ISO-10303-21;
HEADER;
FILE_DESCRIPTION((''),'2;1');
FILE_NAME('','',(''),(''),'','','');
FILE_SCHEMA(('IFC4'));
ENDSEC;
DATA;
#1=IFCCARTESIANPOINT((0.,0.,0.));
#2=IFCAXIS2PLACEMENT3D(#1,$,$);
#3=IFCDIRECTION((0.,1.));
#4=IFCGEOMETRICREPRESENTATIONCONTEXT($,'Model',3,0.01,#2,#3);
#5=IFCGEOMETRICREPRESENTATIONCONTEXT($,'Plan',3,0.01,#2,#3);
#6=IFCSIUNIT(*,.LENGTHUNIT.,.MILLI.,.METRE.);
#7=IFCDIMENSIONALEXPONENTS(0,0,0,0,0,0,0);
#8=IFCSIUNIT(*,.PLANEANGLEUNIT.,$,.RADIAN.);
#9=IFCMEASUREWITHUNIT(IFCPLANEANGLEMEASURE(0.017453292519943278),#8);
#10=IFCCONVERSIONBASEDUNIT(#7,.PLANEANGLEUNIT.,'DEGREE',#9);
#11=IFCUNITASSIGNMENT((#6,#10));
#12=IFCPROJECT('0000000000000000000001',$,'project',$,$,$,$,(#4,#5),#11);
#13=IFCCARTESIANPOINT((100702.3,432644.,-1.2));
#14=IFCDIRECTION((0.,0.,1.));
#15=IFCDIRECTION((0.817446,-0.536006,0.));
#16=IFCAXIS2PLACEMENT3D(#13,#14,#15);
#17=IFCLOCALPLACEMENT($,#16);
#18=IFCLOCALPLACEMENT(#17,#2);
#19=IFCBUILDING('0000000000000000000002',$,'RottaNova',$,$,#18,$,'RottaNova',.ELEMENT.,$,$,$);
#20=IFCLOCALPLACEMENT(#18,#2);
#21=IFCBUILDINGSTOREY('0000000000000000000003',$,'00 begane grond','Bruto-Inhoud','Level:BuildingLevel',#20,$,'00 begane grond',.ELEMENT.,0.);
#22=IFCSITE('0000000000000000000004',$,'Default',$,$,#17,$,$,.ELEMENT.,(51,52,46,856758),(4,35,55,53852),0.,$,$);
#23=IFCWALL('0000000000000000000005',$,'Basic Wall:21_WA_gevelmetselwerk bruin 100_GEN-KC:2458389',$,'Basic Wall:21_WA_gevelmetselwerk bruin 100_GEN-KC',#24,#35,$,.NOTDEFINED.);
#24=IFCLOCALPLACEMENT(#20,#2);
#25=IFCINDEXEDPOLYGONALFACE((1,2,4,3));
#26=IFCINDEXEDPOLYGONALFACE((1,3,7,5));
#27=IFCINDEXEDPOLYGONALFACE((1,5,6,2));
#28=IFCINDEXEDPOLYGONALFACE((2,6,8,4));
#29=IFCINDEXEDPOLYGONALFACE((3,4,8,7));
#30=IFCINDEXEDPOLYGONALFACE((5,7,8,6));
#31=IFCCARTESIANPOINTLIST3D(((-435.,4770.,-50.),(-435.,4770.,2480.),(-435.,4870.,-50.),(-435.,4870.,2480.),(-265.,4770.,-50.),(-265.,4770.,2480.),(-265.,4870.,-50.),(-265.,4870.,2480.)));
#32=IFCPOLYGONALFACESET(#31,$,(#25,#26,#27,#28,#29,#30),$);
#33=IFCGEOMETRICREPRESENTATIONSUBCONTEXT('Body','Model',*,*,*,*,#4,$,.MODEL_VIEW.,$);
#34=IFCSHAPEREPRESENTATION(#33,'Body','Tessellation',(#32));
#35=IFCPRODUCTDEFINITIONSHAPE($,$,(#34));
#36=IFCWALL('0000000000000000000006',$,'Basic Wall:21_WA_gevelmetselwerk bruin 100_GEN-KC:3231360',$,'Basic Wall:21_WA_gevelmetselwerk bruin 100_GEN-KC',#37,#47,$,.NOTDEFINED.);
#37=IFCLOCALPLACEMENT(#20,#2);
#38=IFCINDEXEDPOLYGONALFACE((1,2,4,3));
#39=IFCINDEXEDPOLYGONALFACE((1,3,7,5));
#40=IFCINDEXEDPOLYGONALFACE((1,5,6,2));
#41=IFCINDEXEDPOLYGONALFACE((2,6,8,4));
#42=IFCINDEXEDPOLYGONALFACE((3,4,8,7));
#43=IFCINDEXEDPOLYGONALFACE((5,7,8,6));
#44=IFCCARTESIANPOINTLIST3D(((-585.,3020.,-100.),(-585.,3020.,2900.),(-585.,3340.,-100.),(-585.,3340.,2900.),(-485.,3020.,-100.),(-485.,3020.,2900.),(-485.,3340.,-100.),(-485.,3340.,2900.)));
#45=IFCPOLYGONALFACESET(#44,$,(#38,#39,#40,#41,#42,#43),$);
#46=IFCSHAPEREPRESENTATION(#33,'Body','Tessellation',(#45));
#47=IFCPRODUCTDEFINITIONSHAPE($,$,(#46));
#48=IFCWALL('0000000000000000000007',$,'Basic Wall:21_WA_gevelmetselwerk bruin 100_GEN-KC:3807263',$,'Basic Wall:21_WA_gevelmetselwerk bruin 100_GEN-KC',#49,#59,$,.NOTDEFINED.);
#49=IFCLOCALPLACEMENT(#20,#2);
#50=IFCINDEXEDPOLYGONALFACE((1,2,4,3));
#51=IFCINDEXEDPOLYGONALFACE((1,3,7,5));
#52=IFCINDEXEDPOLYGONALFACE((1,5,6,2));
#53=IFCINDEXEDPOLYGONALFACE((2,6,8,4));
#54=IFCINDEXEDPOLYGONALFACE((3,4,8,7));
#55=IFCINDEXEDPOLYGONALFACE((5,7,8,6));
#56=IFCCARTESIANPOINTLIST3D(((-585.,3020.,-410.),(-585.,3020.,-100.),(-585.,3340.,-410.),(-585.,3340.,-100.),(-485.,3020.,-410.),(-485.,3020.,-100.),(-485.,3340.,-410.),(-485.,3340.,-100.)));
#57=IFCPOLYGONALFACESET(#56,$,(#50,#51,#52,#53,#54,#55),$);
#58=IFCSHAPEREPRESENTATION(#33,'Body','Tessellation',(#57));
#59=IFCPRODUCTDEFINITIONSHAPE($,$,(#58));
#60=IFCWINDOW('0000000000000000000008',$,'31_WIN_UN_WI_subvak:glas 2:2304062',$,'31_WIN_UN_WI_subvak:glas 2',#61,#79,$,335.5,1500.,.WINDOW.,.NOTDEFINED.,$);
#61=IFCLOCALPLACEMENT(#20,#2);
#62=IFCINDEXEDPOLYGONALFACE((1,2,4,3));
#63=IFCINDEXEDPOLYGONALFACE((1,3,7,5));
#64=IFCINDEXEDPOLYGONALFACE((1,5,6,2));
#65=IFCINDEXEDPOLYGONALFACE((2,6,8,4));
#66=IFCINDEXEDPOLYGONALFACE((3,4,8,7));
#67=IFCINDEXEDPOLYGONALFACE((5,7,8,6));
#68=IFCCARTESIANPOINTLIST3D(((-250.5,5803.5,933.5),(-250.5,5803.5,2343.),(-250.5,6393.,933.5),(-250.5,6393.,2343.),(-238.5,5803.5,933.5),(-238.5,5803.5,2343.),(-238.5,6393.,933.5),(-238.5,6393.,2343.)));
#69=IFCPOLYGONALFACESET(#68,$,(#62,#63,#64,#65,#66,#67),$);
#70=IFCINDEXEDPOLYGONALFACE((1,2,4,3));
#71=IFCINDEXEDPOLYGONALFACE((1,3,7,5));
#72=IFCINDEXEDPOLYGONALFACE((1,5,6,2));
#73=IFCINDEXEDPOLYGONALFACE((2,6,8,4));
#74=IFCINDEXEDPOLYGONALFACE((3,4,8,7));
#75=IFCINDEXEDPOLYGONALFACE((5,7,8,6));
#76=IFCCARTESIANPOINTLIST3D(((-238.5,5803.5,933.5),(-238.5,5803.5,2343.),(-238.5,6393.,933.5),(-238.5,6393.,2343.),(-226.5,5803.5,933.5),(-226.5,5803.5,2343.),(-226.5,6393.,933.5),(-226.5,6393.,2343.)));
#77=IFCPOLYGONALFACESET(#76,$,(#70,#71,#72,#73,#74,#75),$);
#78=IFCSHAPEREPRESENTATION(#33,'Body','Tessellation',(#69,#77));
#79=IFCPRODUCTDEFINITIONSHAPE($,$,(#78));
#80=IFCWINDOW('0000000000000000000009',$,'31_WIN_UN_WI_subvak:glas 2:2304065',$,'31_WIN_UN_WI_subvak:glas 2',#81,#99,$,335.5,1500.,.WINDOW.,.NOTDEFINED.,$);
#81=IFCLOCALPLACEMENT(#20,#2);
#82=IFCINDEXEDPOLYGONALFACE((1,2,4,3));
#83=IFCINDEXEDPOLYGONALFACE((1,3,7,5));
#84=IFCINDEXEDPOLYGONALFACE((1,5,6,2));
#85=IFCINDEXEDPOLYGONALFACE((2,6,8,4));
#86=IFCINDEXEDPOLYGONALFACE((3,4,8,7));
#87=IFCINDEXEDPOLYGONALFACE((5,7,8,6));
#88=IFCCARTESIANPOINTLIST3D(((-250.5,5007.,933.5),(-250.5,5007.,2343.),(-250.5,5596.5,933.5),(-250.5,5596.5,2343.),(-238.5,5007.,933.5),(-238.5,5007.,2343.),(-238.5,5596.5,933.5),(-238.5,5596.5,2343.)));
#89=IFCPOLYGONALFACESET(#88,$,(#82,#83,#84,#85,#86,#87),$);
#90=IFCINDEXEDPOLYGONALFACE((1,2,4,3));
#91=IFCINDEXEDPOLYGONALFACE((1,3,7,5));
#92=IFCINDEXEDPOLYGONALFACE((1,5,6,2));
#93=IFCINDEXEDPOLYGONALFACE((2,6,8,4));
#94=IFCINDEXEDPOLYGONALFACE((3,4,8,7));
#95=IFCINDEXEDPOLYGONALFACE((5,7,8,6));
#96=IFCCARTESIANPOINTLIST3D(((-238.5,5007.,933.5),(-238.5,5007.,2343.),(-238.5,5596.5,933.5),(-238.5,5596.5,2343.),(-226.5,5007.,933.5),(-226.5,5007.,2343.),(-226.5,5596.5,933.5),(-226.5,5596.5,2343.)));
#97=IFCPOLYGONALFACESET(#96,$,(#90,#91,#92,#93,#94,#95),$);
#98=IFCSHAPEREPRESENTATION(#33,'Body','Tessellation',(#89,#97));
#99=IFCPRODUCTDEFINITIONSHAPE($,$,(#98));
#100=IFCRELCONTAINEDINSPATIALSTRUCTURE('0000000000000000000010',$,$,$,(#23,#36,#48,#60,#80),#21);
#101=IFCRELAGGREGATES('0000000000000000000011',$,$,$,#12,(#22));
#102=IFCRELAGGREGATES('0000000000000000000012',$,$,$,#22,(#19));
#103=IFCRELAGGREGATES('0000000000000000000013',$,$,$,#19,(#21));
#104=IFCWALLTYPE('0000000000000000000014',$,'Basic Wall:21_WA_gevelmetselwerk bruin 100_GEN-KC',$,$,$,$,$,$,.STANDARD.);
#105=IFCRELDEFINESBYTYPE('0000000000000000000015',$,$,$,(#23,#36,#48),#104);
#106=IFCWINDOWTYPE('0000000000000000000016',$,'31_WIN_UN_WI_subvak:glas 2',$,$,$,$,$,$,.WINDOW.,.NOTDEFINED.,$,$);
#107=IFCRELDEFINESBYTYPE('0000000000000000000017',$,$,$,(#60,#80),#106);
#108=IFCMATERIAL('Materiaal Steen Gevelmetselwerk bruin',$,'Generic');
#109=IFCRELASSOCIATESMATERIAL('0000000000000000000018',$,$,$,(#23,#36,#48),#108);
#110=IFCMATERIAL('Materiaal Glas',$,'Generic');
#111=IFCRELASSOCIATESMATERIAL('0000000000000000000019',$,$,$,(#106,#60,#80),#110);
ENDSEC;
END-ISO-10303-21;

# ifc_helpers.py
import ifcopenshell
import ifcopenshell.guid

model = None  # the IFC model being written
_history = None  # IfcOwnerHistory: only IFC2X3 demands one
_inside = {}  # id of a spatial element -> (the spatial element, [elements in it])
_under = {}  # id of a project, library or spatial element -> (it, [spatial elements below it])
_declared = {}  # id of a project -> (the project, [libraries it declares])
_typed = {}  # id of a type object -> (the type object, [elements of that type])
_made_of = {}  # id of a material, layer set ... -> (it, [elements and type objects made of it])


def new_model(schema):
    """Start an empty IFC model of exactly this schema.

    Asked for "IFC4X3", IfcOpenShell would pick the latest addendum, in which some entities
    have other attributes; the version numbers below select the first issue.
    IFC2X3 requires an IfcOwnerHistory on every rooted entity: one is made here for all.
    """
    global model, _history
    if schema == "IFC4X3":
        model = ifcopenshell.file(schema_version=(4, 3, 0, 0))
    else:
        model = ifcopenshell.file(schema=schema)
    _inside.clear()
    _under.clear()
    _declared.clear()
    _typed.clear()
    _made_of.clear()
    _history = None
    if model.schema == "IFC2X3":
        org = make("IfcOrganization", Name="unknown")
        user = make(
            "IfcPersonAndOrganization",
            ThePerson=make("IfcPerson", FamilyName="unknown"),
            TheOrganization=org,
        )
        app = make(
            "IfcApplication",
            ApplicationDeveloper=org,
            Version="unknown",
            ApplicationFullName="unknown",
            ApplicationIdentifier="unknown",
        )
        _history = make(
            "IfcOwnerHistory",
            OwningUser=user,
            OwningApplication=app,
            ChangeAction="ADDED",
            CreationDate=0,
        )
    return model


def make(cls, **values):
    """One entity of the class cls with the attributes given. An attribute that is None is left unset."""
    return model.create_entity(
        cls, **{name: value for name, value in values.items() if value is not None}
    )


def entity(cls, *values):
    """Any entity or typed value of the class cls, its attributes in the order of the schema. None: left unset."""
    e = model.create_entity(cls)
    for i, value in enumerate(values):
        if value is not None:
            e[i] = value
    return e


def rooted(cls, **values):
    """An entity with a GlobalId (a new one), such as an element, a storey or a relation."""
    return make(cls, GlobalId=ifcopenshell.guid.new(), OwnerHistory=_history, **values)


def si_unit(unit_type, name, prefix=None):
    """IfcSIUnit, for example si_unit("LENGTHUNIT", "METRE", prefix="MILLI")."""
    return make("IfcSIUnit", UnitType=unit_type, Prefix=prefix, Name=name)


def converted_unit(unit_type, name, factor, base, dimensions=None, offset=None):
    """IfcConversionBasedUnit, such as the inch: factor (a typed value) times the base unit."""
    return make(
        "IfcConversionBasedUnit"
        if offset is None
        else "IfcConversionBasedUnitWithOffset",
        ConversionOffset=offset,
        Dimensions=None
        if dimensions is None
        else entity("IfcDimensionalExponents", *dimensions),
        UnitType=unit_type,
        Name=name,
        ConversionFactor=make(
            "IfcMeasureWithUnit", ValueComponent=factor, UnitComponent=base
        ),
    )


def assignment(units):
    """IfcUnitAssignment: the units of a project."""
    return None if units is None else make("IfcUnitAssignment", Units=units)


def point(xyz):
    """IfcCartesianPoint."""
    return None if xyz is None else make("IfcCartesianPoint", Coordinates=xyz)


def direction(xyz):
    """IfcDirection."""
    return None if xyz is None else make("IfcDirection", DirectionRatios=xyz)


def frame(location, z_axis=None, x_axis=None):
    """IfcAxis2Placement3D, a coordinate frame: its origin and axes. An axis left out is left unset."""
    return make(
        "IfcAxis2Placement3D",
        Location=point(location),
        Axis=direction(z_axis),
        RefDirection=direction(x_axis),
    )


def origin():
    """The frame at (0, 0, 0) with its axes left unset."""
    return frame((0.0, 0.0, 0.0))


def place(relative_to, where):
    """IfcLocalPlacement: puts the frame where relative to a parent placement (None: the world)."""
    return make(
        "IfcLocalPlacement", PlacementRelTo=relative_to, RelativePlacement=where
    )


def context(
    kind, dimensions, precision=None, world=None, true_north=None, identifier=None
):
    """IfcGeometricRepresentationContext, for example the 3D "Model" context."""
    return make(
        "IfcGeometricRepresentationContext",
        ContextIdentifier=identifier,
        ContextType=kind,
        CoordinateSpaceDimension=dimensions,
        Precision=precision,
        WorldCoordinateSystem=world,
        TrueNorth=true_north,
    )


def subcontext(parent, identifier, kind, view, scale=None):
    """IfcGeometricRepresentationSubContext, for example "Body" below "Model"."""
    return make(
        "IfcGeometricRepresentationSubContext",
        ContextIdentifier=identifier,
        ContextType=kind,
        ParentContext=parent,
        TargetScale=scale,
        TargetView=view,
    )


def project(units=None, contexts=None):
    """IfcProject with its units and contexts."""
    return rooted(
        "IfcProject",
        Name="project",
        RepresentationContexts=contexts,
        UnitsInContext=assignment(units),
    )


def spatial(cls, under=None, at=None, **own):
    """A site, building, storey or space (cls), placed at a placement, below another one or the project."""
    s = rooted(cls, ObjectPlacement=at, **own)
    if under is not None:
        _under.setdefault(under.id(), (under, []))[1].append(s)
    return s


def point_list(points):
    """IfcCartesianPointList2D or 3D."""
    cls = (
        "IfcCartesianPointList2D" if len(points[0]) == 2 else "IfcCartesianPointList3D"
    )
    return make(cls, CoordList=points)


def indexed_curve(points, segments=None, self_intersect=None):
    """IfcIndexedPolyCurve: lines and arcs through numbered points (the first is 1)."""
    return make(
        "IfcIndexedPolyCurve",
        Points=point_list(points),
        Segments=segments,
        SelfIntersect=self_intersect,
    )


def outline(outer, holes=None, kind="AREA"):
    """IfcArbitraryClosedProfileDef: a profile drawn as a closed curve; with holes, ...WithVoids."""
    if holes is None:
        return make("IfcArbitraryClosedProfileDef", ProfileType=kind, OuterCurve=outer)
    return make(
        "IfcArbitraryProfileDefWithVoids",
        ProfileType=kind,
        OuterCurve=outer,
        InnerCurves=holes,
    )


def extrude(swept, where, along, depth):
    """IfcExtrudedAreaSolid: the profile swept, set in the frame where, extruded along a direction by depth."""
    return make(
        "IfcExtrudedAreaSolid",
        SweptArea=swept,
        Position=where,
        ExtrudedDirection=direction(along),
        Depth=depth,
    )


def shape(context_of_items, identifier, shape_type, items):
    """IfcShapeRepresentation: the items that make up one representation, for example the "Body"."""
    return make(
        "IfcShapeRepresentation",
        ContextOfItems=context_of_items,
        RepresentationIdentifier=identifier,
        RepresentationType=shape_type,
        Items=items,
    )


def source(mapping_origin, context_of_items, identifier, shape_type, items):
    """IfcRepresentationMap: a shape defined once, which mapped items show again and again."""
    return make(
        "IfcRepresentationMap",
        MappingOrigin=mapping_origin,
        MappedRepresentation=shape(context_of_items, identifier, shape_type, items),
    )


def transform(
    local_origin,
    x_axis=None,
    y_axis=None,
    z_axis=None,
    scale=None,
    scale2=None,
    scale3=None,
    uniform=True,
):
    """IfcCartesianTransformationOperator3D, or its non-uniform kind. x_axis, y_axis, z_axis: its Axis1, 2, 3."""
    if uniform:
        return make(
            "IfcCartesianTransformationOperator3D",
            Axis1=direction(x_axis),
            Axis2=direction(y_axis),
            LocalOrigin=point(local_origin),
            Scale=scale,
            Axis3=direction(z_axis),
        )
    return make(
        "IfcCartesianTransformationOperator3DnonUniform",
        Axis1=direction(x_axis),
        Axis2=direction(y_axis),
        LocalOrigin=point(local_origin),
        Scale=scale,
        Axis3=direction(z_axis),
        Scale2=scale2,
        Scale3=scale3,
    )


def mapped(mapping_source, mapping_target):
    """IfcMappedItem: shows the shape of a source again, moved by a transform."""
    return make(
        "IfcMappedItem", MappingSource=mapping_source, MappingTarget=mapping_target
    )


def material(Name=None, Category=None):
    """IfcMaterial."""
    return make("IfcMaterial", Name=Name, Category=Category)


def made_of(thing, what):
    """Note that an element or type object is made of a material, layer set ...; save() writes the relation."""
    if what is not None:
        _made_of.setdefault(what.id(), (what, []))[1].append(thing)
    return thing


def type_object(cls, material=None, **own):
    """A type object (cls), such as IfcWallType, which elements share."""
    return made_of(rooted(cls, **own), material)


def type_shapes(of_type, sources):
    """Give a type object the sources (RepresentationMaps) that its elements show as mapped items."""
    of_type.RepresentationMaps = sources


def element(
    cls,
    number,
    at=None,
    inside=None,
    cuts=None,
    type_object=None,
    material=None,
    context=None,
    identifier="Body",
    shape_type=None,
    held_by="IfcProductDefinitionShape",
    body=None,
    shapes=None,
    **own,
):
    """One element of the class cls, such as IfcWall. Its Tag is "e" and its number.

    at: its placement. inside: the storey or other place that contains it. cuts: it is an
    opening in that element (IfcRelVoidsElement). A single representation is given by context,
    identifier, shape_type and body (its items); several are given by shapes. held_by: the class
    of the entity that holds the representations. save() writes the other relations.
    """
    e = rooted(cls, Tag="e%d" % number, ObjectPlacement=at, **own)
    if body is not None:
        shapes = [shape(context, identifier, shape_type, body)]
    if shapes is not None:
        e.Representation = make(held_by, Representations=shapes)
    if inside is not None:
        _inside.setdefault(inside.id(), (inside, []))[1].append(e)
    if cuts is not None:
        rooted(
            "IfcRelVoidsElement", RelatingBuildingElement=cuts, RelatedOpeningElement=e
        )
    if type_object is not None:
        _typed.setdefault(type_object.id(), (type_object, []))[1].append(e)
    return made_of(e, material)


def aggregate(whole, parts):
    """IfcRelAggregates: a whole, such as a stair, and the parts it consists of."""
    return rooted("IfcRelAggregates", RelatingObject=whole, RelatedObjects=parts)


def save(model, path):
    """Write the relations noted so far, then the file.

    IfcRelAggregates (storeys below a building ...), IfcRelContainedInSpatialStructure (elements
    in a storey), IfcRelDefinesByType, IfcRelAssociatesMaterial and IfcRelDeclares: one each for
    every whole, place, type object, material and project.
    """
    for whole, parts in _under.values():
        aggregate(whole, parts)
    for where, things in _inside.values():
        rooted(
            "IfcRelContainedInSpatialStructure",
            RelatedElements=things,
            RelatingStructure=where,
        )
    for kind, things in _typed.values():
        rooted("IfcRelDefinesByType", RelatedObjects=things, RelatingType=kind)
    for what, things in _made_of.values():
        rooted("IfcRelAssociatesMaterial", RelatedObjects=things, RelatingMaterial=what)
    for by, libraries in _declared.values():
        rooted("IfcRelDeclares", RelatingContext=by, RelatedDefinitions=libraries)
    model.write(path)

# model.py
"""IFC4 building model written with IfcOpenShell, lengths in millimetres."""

from ifc_helpers import new_model, entity, si_unit, converted_unit, direction, frame, origin, place, context, subcontext, project, spatial, indexed_curve, outline, extrude, source, transform, mapped, material, type_object, type_shapes, element, save


model = new_model("IFC4")

# Units and contexts
model_context = context("Model", 3, precision=0.01, world=origin(), true_north=direction((0.0, 1.0)))
plan_context = context("Plan", 3, precision=0.01, world=origin(), true_north=direction((0.0, 1.0)))
body_context = subcontext(model_context, "Body", "Model", "MODEL_VIEW")
ifc_project = project(units=[si_unit("LENGTHUNIT", "METRE", prefix="MILLI"), converted_unit("PLANEANGLEUNIT", "DEGREE", entity("IfcPlaneAngleMeasure", 0.017453292519943278), si_unit("PLANEANGLEUNIT", "RADIAN"), dimensions=[0, 0, 0, 0, 0, 0, 0])], contexts=[model_context, plan_context])

# Site, building, storey
site_placement = place(None, frame((100702.3, 432644.0, -1.2), z_axis=(0.0, 0.0, 1.0), x_axis=(0.817446, -0.536006, 0.0)))
site = spatial("IfcSite", under=ifc_project, at=site_placement, Name="Default", CompositionType="ELEMENT", RefLatitude=(51, 52, 46, 856758), RefLongitude=(4, 35, 55, 53852), RefElevation=0.0)
building_placement = place(site_placement, origin())
building = spatial("IfcBuilding", under=site, at=building_placement, Name="RottaNova", LongName="RottaNova", CompositionType="ELEMENT")
storey_placement = place(building_placement, origin())
storey = spatial("IfcBuildingStorey", under=building, at=storey_placement, Name="00 begane grond", Description="Bruto-Inhoud", ObjectType="Level:BuildingLevel", LongName="00 begane grond", CompositionType="ELEMENT", Elevation=0.0)

# Shared definitions
ifc_material_1 = material(Name="Materiaal Glas", Category="Generic")

# Walls
ifc_material_2 = material(Name="Materiaal Steen Gevelmetselwerk bruin", Category="Generic")
wall_type_1 = type_object("IfcWallType", Name="Basic Wall:21_WA_gevelmetselwerk bruin 100_GEN-KC", PredefinedType="STANDARD")
wall_1_placement = place(storey_placement, frame((-435.0, 4820.0, -50.0)))
element("IfcWall", 1, at=wall_1_placement, inside=storey, type_object=wall_type_1, material=ifc_material_2, Name="Basic Wall:21_WA_gevelmetselwerk bruin 100_GEN-KC:2458389", ObjectType="Basic Wall:21_WA_gevelmetselwerk bruin 100_GEN-KC", PredefinedType="NOTDEFINED", context=body_context, shape_type="SweptSolid", body=[
    extrude(outline(indexed_curve([(170.0, 50.0), (0.0, 50.0), (0.0, -50.0), (170.0, -50.0), (170.0, 50.0)], self_intersect=False)), origin(), (0.0, 0.0, 1.0), 2530.0),
])
wall_2_placement = place(storey_placement, frame((-535.0, 3340.0, -100.0), z_axis=(0.0, 0.0, 1.0), x_axis=(0.0, -1.0, 0.0)))
element("IfcWall", 2, at=wall_2_placement, inside=storey, type_object=wall_type_1, material=ifc_material_2, Name="Basic Wall:21_WA_gevelmetselwerk bruin 100_GEN-KC:3231360", ObjectType="Basic Wall:21_WA_gevelmetselwerk bruin 100_GEN-KC", PredefinedType="NOTDEFINED", context=body_context, shape_type="SweptSolid", body=[
    extrude(outline(indexed_curve([(320.0, 50.0), (0.0, 50.0), (0.0, -50.0), (320.0, -50.0), (320.0, 50.0)], self_intersect=False)), origin(), (0.0, 0.0, 1.0), 3000.0),
])
wall_3_placement = place(storey_placement, frame((-535.0, 3340.0, -410.0), z_axis=(0.0, 0.0, 1.0), x_axis=(0.0, -1.0, 0.0)))
element("IfcWall", 3, at=wall_3_placement, inside=storey, type_object=wall_type_1, material=ifc_material_2, Name="Basic Wall:21_WA_gevelmetselwerk bruin 100_GEN-KC:3807263", ObjectType="Basic Wall:21_WA_gevelmetselwerk bruin 100_GEN-KC", PredefinedType="NOTDEFINED", context=body_context, shape_type="SweptSolid", body=[
    extrude(outline(indexed_curve([(320.0, 50.0), (0.0, 50.0), (0.0, -50.0), (320.0, -50.0), (320.0, 50.0)], self_intersect=False)), origin(), (0.0, 0.0, 1.0), 310.0),
])

# Windows
window_type = type_object("IfcWindowType", Name="31_WIN_UN_WI_subvak:glas 2", PartitioningType="NOTDEFINED", PredefinedType="WINDOW", material=ifc_material_1)
shared_shape_1 = source(origin(), body_context, "Body", "SweptSolid", [
    extrude(outline(indexed_curve([(-294.7, -6.0), (294.7, -6.0), (294.7, 6.0), (-294.7, 6.0), (-294.7, -6.0)], self_intersect=False)), frame((0.0, -6.0, 0.0)), (0.0, 0.0, 1.0), 1409.5),
    extrude(outline(indexed_curve([(-294.8, -6.0), (294.8, -6.0), (294.8, 6.0), (-294.8, 6.0), (-294.8, -6.0)], self_intersect=False)), frame((0.0, 6.0, 0.0)), (0.0, 0.0, 1.0), 1409.5),
])
type_shapes(window_type, [shared_shape_1])
for number, where, z_axis, x_axis, name in (
    (4, (-238.5, 6098.2, 933.5), (0.0, 0.0, 1.0), (0.0, -1.0, 0.0), "31_WIN_UN_WI_subvak:glas 2:2304062"),
    (5, (-238.5, 5301.7, 933.5), (0.0, 0.0, 1.0), (0.0, -1.0, 0.0), "31_WIN_UN_WI_subvak:glas 2:2304065"),
):
    element("IfcWindow", number, at=place(storey_placement, frame(where, z_axis=z_axis, x_axis=x_axis)), inside=storey, type_object=window_type, material=ifc_material_1, Name=name, ObjectType="31_WIN_UN_WI_subvak:glas 2", OverallHeight=335.5, OverallWidth=1500.0, PartitioningType="NOTDEFINED", PredefinedType="WINDOW", context=body_context, shape_type="MappedRepresentation", body=[
        mapped(shared_shape_1, transform((0.0, 0.0, 0.0), scale=1.0)),
    ])

save(model, "model.ifc")
